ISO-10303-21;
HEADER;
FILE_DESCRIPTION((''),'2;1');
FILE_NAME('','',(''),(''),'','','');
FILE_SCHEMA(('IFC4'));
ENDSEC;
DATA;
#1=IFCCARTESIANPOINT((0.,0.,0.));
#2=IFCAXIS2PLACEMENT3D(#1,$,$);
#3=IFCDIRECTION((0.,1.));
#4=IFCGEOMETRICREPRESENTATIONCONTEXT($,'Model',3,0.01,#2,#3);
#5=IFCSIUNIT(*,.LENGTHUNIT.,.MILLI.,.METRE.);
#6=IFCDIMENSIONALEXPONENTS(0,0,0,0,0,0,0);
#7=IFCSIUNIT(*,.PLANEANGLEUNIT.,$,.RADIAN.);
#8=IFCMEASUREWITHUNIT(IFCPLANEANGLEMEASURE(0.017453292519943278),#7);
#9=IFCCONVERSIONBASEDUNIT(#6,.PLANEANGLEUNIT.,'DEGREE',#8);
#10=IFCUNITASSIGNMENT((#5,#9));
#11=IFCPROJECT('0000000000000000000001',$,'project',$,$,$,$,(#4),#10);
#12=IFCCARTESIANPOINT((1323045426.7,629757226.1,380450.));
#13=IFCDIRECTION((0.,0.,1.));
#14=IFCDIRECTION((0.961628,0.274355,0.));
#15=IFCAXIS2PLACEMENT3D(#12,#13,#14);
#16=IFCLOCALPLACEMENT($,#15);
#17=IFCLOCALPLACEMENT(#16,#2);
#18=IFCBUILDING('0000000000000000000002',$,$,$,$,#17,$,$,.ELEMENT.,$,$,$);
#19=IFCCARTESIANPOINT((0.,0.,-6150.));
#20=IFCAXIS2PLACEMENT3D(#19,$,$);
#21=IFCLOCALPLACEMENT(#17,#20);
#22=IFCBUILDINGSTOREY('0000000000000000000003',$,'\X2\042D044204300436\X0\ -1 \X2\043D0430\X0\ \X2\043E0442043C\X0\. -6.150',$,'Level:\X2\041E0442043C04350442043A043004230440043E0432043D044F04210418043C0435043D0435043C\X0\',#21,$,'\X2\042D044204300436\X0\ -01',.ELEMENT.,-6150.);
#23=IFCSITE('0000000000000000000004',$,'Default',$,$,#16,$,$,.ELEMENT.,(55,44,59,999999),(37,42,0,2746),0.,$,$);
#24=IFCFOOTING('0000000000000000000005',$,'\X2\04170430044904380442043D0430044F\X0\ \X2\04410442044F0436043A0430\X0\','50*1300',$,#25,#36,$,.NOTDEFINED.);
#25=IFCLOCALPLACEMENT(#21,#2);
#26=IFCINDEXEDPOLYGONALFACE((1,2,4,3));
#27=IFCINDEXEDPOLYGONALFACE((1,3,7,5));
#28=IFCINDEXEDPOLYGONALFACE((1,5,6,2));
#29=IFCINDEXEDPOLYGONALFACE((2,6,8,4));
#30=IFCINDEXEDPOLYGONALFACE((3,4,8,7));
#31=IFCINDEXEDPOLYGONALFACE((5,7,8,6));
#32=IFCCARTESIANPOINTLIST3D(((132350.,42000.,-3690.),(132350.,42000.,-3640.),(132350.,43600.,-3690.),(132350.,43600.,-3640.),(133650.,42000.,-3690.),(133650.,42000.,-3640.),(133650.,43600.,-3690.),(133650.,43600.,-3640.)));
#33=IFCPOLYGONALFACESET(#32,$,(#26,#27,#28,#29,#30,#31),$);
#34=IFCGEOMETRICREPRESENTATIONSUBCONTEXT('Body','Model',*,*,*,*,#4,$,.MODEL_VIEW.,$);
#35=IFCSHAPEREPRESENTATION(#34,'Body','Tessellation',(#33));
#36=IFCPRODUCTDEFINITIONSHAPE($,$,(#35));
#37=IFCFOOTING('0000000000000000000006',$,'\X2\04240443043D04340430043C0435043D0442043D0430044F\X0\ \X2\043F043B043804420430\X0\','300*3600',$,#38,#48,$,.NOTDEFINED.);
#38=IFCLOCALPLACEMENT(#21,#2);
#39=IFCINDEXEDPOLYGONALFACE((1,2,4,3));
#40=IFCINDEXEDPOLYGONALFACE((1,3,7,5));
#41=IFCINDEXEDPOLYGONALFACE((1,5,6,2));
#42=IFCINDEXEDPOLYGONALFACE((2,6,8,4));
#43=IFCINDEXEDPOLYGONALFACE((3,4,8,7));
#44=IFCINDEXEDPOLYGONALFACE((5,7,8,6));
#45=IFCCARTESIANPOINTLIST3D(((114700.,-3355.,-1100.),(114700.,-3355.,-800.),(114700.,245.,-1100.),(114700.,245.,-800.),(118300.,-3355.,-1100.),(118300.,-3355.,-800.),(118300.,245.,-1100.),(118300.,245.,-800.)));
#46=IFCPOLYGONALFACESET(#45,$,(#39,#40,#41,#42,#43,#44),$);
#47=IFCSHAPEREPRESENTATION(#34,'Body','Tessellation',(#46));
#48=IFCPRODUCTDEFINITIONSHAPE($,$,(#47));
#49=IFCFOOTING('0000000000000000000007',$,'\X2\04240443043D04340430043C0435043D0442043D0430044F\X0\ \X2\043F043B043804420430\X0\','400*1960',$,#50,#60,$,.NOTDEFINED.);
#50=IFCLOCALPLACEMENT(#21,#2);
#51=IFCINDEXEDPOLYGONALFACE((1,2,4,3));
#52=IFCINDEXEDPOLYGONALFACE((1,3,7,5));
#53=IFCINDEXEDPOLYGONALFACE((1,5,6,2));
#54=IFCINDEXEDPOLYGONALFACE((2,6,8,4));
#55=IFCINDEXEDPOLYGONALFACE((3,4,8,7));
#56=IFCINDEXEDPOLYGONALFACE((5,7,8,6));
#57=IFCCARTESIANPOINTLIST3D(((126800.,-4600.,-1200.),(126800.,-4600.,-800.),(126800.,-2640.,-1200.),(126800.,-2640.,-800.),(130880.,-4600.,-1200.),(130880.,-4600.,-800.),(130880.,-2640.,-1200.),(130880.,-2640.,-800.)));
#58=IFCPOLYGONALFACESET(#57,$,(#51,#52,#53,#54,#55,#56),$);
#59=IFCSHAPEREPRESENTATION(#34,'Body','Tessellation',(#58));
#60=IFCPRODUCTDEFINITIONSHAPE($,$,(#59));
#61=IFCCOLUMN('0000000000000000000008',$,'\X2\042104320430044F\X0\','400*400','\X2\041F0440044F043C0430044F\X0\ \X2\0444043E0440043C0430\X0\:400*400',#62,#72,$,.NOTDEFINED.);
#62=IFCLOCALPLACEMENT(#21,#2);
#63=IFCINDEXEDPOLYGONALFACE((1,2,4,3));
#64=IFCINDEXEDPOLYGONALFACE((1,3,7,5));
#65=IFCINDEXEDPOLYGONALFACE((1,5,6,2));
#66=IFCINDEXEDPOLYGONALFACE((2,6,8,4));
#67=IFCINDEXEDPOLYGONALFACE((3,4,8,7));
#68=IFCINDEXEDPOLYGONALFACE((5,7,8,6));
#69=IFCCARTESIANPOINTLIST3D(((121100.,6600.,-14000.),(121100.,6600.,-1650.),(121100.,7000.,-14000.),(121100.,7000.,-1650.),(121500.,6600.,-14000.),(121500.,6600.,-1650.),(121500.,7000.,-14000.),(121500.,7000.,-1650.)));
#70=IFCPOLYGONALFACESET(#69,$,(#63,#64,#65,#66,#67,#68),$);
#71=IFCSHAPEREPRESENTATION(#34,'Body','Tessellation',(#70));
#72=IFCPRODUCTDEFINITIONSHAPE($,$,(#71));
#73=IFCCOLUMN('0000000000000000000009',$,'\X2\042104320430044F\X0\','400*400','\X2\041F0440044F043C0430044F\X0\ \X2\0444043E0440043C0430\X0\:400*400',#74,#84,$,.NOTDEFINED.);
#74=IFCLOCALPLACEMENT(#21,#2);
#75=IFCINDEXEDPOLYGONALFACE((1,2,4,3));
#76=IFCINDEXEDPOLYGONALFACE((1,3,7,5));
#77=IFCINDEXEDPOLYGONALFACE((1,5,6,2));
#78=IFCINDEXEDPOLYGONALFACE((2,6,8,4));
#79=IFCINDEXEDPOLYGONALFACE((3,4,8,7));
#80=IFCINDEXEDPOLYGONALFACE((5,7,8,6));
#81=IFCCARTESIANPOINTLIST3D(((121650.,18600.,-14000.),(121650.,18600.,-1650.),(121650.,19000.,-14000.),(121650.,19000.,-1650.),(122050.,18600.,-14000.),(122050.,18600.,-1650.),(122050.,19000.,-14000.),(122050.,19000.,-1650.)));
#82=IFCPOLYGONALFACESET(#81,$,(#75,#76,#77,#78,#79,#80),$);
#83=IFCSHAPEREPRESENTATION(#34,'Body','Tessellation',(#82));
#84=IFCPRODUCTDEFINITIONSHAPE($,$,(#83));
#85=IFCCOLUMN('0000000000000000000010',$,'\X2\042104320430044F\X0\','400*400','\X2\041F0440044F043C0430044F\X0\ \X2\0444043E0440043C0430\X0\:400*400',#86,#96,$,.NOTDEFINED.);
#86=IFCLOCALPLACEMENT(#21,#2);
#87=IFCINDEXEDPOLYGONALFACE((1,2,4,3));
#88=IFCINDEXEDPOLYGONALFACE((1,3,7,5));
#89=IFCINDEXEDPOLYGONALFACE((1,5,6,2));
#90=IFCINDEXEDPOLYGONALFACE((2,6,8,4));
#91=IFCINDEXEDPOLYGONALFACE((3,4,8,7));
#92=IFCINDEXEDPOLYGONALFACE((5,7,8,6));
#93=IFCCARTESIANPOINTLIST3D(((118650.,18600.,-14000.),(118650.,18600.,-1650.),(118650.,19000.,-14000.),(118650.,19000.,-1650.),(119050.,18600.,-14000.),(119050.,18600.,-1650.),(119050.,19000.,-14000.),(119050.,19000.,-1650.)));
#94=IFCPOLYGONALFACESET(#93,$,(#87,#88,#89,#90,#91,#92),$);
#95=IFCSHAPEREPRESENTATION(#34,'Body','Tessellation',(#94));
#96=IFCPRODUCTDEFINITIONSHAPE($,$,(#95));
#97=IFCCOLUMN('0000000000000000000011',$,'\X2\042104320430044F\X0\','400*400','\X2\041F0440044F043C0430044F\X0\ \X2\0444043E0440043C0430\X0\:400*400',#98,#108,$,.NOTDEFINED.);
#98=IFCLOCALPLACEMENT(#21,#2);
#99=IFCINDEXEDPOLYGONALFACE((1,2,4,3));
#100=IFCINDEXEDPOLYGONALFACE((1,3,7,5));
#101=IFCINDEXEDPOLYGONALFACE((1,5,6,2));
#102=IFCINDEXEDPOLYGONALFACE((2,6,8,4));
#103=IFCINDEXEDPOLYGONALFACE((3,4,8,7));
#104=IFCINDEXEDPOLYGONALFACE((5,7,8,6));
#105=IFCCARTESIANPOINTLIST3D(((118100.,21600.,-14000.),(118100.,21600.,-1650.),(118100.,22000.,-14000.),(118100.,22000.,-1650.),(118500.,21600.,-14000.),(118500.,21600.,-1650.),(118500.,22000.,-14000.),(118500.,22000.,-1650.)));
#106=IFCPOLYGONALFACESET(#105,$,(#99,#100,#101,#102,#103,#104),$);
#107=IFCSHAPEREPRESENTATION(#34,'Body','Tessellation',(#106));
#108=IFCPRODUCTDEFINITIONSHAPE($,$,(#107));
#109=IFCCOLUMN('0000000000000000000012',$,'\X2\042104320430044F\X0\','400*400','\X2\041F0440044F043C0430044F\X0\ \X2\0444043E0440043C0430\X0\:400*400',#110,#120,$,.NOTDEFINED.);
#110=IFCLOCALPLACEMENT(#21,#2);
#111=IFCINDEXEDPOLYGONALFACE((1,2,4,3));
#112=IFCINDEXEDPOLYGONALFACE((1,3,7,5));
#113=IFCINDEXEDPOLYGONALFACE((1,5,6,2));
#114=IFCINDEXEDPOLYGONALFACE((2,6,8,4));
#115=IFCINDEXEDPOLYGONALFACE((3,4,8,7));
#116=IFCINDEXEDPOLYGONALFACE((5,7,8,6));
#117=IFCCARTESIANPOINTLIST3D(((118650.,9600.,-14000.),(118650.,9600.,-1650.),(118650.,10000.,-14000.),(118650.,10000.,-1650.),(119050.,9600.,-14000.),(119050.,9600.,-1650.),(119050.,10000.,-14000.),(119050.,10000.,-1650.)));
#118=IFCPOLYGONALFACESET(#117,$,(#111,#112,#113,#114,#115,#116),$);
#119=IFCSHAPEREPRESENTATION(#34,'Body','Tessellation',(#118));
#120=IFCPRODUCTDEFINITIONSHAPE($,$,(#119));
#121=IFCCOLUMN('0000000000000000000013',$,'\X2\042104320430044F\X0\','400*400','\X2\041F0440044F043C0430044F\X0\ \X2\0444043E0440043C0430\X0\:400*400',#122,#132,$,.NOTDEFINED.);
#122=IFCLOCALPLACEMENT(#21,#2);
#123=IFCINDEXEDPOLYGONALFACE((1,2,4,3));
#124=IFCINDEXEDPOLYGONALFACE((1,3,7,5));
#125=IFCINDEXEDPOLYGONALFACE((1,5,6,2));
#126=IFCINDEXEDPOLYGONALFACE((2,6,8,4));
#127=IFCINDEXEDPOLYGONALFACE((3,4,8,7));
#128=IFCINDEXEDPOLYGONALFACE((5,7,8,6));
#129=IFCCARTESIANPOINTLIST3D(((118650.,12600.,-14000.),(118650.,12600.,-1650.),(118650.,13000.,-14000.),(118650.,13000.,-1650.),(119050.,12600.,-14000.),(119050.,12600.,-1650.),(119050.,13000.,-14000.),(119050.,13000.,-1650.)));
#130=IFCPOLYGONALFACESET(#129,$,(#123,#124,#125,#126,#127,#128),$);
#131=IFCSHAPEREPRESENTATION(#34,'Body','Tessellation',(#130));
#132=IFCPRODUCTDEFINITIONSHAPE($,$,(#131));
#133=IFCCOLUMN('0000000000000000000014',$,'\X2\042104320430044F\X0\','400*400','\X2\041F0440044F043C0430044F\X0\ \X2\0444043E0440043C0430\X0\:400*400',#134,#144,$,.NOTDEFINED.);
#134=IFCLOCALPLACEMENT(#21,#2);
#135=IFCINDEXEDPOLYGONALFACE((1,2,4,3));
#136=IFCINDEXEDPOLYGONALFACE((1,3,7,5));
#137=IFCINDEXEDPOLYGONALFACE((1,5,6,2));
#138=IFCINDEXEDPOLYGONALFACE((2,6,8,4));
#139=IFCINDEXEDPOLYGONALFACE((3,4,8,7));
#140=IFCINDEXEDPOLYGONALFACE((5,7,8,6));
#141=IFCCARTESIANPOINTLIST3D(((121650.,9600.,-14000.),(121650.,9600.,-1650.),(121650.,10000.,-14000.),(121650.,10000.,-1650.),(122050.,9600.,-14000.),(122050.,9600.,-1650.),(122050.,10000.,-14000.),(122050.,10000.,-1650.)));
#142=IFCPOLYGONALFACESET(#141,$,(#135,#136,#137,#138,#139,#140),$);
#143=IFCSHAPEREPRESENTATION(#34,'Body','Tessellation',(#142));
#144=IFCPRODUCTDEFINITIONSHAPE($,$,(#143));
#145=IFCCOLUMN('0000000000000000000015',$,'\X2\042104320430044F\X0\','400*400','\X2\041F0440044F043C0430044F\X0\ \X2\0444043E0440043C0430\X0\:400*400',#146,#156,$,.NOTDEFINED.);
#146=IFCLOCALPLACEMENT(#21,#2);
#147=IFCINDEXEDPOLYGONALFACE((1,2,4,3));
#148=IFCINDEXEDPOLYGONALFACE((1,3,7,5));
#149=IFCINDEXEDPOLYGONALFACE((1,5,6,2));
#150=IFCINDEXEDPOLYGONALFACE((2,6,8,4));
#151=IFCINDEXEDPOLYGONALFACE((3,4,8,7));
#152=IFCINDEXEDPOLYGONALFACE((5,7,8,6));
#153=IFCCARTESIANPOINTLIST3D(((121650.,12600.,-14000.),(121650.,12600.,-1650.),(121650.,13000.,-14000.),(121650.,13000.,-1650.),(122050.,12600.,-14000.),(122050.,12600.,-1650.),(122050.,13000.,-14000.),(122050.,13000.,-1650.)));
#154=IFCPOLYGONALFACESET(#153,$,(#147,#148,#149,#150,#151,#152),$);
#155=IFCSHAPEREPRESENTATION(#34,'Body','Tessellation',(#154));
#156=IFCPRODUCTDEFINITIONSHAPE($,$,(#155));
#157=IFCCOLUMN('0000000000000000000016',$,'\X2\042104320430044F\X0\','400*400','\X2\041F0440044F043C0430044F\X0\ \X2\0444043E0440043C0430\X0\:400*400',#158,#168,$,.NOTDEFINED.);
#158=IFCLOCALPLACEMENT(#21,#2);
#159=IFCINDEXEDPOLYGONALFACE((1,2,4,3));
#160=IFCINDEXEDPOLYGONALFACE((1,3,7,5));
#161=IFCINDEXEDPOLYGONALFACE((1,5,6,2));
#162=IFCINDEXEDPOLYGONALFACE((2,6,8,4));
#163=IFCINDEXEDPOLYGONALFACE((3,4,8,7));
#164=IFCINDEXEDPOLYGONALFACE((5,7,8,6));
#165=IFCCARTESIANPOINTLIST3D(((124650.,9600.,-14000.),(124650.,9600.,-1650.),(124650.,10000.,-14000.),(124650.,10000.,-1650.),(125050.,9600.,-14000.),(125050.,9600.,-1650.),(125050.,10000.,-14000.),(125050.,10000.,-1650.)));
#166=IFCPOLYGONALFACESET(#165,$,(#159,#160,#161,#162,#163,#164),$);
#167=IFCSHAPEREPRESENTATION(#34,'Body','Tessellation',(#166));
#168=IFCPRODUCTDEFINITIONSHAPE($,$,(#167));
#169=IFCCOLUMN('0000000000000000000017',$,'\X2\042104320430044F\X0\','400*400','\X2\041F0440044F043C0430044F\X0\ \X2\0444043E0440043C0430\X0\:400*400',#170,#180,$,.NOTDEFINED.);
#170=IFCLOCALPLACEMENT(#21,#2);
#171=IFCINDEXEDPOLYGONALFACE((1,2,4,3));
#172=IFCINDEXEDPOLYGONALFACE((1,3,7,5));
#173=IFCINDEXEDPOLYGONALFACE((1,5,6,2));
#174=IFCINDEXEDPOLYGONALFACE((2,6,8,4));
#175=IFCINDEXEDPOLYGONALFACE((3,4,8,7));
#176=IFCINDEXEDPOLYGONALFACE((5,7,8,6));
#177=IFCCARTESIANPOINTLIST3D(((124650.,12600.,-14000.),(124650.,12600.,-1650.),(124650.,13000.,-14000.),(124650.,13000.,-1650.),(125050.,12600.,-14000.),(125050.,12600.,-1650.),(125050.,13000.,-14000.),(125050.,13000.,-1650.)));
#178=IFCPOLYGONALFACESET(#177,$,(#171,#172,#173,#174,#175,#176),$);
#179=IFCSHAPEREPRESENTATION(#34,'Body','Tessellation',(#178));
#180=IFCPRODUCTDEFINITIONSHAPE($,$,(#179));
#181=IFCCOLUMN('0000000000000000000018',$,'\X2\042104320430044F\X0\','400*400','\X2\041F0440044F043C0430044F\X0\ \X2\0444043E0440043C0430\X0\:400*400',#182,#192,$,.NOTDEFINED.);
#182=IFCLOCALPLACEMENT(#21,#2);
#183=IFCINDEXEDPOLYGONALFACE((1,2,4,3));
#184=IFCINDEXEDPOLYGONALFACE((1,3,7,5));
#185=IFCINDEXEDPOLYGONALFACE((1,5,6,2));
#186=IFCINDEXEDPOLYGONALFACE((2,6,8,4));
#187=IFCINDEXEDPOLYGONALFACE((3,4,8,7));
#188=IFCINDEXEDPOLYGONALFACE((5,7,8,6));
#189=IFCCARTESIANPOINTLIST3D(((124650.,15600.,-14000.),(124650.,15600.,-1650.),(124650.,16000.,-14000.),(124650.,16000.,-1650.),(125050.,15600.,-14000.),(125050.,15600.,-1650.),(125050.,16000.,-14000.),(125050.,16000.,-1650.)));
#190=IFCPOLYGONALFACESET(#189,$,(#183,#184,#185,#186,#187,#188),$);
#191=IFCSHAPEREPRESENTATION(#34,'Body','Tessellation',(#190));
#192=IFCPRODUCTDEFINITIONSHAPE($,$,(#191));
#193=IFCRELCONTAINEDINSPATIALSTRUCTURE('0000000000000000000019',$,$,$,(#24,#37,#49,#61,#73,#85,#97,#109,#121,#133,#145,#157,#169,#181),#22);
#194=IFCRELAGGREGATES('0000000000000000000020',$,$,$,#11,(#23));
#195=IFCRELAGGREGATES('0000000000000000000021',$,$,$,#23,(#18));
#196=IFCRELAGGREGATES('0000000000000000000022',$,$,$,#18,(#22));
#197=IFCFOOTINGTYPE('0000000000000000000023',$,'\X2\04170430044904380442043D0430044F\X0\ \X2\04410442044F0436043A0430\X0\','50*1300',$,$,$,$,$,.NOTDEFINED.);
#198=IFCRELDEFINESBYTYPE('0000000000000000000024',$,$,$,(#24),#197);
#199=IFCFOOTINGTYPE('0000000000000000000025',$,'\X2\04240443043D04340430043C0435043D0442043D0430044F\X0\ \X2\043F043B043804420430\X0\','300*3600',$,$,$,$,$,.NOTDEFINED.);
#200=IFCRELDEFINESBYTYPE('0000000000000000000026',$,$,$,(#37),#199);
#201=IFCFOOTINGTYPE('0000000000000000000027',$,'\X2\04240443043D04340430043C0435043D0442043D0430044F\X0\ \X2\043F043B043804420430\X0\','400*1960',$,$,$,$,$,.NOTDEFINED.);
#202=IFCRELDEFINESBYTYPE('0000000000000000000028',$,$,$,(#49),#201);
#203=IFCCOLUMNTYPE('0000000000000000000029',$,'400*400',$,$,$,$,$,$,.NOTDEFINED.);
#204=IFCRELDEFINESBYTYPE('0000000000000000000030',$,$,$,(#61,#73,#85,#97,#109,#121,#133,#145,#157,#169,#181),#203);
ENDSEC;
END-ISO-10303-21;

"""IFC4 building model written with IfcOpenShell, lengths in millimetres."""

from ifc_helpers import new_model, entity, si_unit, converted_unit, direction, frame, origin, place, context, subcontext, project, spatial, indexed_curve, outline, extrude, type_object, element, save


model = new_model("IFC4")

# Units and contexts
model_context = context("Model", 3, precision=0.01, world=origin(), true_north=direction((0.0, 1.0)))
body_context = subcontext(model_context, "Body", "Model", "MODEL_VIEW")
ifc_project = project(units=[si_unit("LENGTHUNIT", "METRE", prefix="MILLI"), converted_unit("PLANEANGLEUNIT", "DEGREE", entity("IfcPlaneAngleMeasure", 0.017453292519943278), si_unit("PLANEANGLEUNIT", "RADIAN"), dimensions=[0, 0, 0, 0, 0, 0, 0])], contexts=[model_context])

# Site, building, storey
site_placement = place(None, frame((1323045426.7, 629757226.1, 380450.0), z_axis=(0.0, 0.0, 1.0), x_axis=(0.961628, 0.274355, 0.0)))
site = spatial("IfcSite", under=ifc_project, at=site_placement, Name="Default", CompositionType="ELEMENT", RefLatitude=(55, 44, 59, 999999), RefLongitude=(37, 42, 0, 2746), RefElevation=0.0)
building_placement = place(site_placement, origin())
building = spatial("IfcBuilding", under=site, at=building_placement, CompositionType="ELEMENT")
storey_placement = place(building_placement, frame((0.0, 0.0, -6150.0)))
storey = spatial("IfcBuildingStorey", under=building, at=storey_placement, Name="Этаж -1 на отм. -6.150", ObjectType="Level:ОтметкаУровняСИменем", LongName="Этаж -01", CompositionType="ELEMENT", Elevation=-6150.0)

# Footings
footing_type_1 = type_object("IfcFootingType", Name="Защитная стяжка", Description="50*1300", PredefinedType="NOTDEFINED")
footing_1_placement = place(storey_placement, origin())
element("IfcFooting", 1, at=footing_1_placement, inside=storey, type_object=footing_type_1, Name="Защитная стяжка", Description="50*1300", PredefinedType="NOTDEFINED", context=body_context, shape_type="SweptSolid", body=[
    extrude(outline(indexed_curve([(-650.0, -800.0), (650.0, -800.0), (650.0, 800.0), (-650.0, 800.0), (-650.0, -800.0)], self_intersect=False)), frame((133000.0, 42800.0, -3690.0), z_axis=(0.0, 0.0, 1.0), x_axis=(-1.0, 0.0, 0.0)), (0.0, 0.0, 1.0), 50.0),
])
footing_type_2 = type_object("IfcFootingType", Name="Фундаментная плита", Description="300*3600", PredefinedType="NOTDEFINED")
footing_2_placement = place(storey_placement, origin())
element("IfcFooting", 2, at=footing_2_placement, inside=storey, type_object=footing_type_2, Name="Фундаментная плита", Description="300*3600", PredefinedType="NOTDEFINED", context=body_context, shape_type="SweptSolid", body=[
    extrude(outline(indexed_curve([(-1800.0, -1800.0), (1800.0, -1800.0), (1800.0, 1800.0), (-1800.0, 1800.0), (-1800.0, -1800.0)], self_intersect=False)), frame((116500.0, -1555.0, -1100.0)), (0.0, 0.0, 1.0), 300.0),
])
footing_type_3 = type_object("IfcFootingType", Name="Фундаментная плита", Description="400*1960", PredefinedType="NOTDEFINED")
footing_3_placement = place(storey_placement, origin())
element("IfcFooting", 3, at=footing_3_placement, inside=storey, type_object=footing_type_3, Name="Фундаментная плита", Description="400*1960", PredefinedType="NOTDEFINED", context=body_context, shape_type="SweptSolid", body=[
    extrude(outline(indexed_curve([(-2040.0, -980.0), (2040.0, -980.0), (2040.0, 980.0), (-2040.0, 980.0), (-2040.0, -980.0)], self_intersect=False)), frame((128840.0, -3620.0, -1200.0), z_axis=(0.0, 0.0, 1.0), x_axis=(-1.0, 0.0, 0.0)), (0.0, 0.0, 1.0), 400.0),
])

# Columns
column_type = type_object("IfcColumnType", Name="400*400", PredefinedType="NOTDEFINED")
column_1_placement = place(storey_placement, origin())
element("IfcColumn", 4, at=column_1_placement, inside=storey, type_object=column_type, Name="Свая", Description="400*400", ObjectType="Прямая форма:400*400", PredefinedType="NOTDEFINED", context=body_context, shape_type="SweptSolid", body=[
    extrude(outline(indexed_curve([(-200.0, -200.0), (200.0, -200.0), (200.0, 200.0), (-200.0, 200.0), (-200.0, -200.0)], self_intersect=False)), frame((121300.0, 6800.0, -14000.0), z_axis=(0.0, 0.0, 1.0), x_axis=(0.0, 1.0, 0.0)), (0.0, 0.0, 1.0), 12350.0),
])
column_2_placement = place(storey_placement, origin())
element("IfcColumn", 5, at=column_2_placement, inside=storey, type_object=column_type, Name="Свая", Description="400*400", ObjectType="Прямая форма:400*400", PredefinedType="NOTDEFINED", context=body_context, shape_type="SweptSolid", body=[
    extrude(outline(indexed_curve([(-200.0, -200.0), (200.0, -200.0), (200.0, 200.0), (-200.0, 200.0), (-200.0, -200.0)], self_intersect=False)), frame((121850.0, 18800.0, -14000.0), z_axis=(0.0, 0.0, 1.0), x_axis=(0.0, 1.0, 0.0)), (0.0, 0.0, 1.0), 12350.0),
])
column_3_placement = place(storey_placement, origin())
element("IfcColumn", 6, at=column_3_placement, inside=storey, type_object=column_type, Name="Свая", Description="400*400", ObjectType="Прямая форма:400*400", PredefinedType="NOTDEFINED", context=body_context, shape_type="SweptSolid", body=[
    extrude(outline(indexed_curve([(-200.0, -200.0), (200.0, -200.0), (200.0, 200.0), (-200.0, 200.0), (-200.0, -200.0)], self_intersect=False)), frame((118850.0, 18800.0, -14000.0), z_axis=(0.0, 0.0, 1.0), x_axis=(0.0, 1.0, 0.0)), (0.0, 0.0, 1.0), 12350.0),
])
column_4_placement = place(storey_placement, origin())
element("IfcColumn", 7, at=column_4_placement, inside=storey, type_object=column_type, Name="Свая", Description="400*400", ObjectType="Прямая форма:400*400", PredefinedType="NOTDEFINED", context=body_context, shape_type="SweptSolid", body=[
    extrude(outline(indexed_curve([(-200.0, -200.0), (200.0, -200.0), (200.0, 200.0), (-200.0, 200.0), (-200.0, -200.0)], self_intersect=False)), frame((118300.0, 21800.0, -14000.0), z_axis=(0.0, 0.0, 1.0), x_axis=(0.0, 1.0, 0.0)), (0.0, 0.0, 1.0), 12350.0),
])
column_5_placement = place(storey_placement, origin())
element("IfcColumn", 8, at=column_5_placement, inside=storey, type_object=column_type, Name="Свая", Description="400*400", ObjectType="Прямая форма:400*400", PredefinedType="NOTDEFINED", context=body_context, shape_type="SweptSolid", body=[
    extrude(outline(indexed_curve([(-200.0, -200.0), (200.0, -200.0), (200.0, 200.0), (-200.0, 200.0), (-200.0, -200.0)], self_intersect=False)), frame((118850.0, 9800.0, -14000.0), z_axis=(0.0, 0.0, 1.0), x_axis=(0.0, 1.0, 0.0)), (0.0, 0.0, 1.0), 12350.0),
])
column_6_placement = place(storey_placement, origin())
element("IfcColumn", 9, at=column_6_placement, inside=storey, type_object=column_type, Name="Свая", Description="400*400", ObjectType="Прямая форма:400*400", PredefinedType="NOTDEFINED", context=body_context, shape_type="SweptSolid", body=[
    extrude(outline(indexed_curve([(-200.0, -200.0), (200.0, -200.0), (200.0, 200.0), (-200.0, 200.0), (-200.0, -200.0)], self_intersect=False)), frame((118850.0, 12800.0, -14000.0), z_axis=(0.0, 0.0, 1.0), x_axis=(0.0, 1.0, 0.0)), (0.0, 0.0, 1.0), 12350.0),
])
column_7_placement = place(storey_placement, origin())
element("IfcColumn", 10, at=column_7_placement, inside=storey, type_object=column_type, Name="Свая", Description="400*400", ObjectType="Прямая форма:400*400", PredefinedType="NOTDEFINED", context=body_context, shape_type="SweptSolid", body=[
    extrude(outline(indexed_curve([(-200.0, -200.0), (200.0, -200.0), (200.0, 200.0), (-200.0, 200.0), (-200.0, -200.0)], self_intersect=False)), frame((121850.0, 9800.0, -14000.0), z_axis=(0.0, 0.0, 1.0), x_axis=(0.0, 1.0, 0.0)), (0.0, 0.0, 1.0), 12350.0),
])
column_8_placement = place(storey_placement, origin())
element("IfcColumn", 11, at=column_8_placement, inside=storey, type_object=column_type, Name="Свая", Description="400*400", ObjectType="Прямая форма:400*400", PredefinedType="NOTDEFINED", context=body_context, shape_type="SweptSolid", body=[
    extrude(outline(indexed_curve([(-200.0, -200.0), (200.0, -200.0), (200.0, 200.0), (-200.0, 200.0), (-200.0, -200.0)], self_intersect=False)), frame((121850.0, 12800.0, -14000.0), z_axis=(0.0, 0.0, 1.0), x_axis=(0.0, 1.0, 0.0)), (0.0, 0.0, 1.0), 12350.0),
])
column_9_placement = place(storey_placement, origin())
element("IfcColumn", 12, at=column_9_placement, inside=storey, type_object=column_type, Name="Свая", Description="400*400", ObjectType="Прямая форма:400*400", PredefinedType="NOTDEFINED", context=body_context, shape_type="SweptSolid", body=[
    extrude(outline(indexed_curve([(-200.0, -200.0), (200.0, -200.0), (200.0, 200.0), (-200.0, 200.0), (-200.0, -200.0)], self_intersect=False)), frame((124850.0, 9800.0, -14000.0), z_axis=(0.0, 0.0, 1.0), x_axis=(0.0, 1.0, 0.0)), (0.0, 0.0, 1.0), 12350.0),
])
column_10_placement = place(storey_placement, origin())
element("IfcColumn", 13, at=column_10_placement, inside=storey, type_object=column_type, Name="Свая", Description="400*400", ObjectType="Прямая форма:400*400", PredefinedType="NOTDEFINED", context=body_context, shape_type="SweptSolid", body=[
    extrude(outline(indexed_curve([(-200.0, -200.0), (200.0, -200.0), (200.0, 200.0), (-200.0, 200.0), (-200.0, -200.0)], self_intersect=False)), frame((124850.0, 12800.0, -14000.0), z_axis=(0.0, 0.0, 1.0), x_axis=(0.0, 1.0, 0.0)), (0.0, 0.0, 1.0), 12350.0),
])
column_11_placement = place(storey_placement, origin())
element("IfcColumn", 14, at=column_11_placement, inside=storey, type_object=column_type, Name="Свая", Description="400*400", ObjectType="Прямая форма:400*400", PredefinedType="NOTDEFINED", context=body_context, shape_type="SweptSolid", body=[
    extrude(outline(indexed_curve([(-200.0, -200.0), (200.0, -200.0), (200.0, 200.0), (-200.0, 200.0), (-200.0, -200.0)], self_intersect=False)), frame((124850.0, 15800.0, -14000.0), z_axis=(0.0, 0.0, 1.0), x_axis=(0.0, 1.0, 0.0)), (0.0, 0.0, 1.0), 12350.0),
])

save(model, "model.ifc")
